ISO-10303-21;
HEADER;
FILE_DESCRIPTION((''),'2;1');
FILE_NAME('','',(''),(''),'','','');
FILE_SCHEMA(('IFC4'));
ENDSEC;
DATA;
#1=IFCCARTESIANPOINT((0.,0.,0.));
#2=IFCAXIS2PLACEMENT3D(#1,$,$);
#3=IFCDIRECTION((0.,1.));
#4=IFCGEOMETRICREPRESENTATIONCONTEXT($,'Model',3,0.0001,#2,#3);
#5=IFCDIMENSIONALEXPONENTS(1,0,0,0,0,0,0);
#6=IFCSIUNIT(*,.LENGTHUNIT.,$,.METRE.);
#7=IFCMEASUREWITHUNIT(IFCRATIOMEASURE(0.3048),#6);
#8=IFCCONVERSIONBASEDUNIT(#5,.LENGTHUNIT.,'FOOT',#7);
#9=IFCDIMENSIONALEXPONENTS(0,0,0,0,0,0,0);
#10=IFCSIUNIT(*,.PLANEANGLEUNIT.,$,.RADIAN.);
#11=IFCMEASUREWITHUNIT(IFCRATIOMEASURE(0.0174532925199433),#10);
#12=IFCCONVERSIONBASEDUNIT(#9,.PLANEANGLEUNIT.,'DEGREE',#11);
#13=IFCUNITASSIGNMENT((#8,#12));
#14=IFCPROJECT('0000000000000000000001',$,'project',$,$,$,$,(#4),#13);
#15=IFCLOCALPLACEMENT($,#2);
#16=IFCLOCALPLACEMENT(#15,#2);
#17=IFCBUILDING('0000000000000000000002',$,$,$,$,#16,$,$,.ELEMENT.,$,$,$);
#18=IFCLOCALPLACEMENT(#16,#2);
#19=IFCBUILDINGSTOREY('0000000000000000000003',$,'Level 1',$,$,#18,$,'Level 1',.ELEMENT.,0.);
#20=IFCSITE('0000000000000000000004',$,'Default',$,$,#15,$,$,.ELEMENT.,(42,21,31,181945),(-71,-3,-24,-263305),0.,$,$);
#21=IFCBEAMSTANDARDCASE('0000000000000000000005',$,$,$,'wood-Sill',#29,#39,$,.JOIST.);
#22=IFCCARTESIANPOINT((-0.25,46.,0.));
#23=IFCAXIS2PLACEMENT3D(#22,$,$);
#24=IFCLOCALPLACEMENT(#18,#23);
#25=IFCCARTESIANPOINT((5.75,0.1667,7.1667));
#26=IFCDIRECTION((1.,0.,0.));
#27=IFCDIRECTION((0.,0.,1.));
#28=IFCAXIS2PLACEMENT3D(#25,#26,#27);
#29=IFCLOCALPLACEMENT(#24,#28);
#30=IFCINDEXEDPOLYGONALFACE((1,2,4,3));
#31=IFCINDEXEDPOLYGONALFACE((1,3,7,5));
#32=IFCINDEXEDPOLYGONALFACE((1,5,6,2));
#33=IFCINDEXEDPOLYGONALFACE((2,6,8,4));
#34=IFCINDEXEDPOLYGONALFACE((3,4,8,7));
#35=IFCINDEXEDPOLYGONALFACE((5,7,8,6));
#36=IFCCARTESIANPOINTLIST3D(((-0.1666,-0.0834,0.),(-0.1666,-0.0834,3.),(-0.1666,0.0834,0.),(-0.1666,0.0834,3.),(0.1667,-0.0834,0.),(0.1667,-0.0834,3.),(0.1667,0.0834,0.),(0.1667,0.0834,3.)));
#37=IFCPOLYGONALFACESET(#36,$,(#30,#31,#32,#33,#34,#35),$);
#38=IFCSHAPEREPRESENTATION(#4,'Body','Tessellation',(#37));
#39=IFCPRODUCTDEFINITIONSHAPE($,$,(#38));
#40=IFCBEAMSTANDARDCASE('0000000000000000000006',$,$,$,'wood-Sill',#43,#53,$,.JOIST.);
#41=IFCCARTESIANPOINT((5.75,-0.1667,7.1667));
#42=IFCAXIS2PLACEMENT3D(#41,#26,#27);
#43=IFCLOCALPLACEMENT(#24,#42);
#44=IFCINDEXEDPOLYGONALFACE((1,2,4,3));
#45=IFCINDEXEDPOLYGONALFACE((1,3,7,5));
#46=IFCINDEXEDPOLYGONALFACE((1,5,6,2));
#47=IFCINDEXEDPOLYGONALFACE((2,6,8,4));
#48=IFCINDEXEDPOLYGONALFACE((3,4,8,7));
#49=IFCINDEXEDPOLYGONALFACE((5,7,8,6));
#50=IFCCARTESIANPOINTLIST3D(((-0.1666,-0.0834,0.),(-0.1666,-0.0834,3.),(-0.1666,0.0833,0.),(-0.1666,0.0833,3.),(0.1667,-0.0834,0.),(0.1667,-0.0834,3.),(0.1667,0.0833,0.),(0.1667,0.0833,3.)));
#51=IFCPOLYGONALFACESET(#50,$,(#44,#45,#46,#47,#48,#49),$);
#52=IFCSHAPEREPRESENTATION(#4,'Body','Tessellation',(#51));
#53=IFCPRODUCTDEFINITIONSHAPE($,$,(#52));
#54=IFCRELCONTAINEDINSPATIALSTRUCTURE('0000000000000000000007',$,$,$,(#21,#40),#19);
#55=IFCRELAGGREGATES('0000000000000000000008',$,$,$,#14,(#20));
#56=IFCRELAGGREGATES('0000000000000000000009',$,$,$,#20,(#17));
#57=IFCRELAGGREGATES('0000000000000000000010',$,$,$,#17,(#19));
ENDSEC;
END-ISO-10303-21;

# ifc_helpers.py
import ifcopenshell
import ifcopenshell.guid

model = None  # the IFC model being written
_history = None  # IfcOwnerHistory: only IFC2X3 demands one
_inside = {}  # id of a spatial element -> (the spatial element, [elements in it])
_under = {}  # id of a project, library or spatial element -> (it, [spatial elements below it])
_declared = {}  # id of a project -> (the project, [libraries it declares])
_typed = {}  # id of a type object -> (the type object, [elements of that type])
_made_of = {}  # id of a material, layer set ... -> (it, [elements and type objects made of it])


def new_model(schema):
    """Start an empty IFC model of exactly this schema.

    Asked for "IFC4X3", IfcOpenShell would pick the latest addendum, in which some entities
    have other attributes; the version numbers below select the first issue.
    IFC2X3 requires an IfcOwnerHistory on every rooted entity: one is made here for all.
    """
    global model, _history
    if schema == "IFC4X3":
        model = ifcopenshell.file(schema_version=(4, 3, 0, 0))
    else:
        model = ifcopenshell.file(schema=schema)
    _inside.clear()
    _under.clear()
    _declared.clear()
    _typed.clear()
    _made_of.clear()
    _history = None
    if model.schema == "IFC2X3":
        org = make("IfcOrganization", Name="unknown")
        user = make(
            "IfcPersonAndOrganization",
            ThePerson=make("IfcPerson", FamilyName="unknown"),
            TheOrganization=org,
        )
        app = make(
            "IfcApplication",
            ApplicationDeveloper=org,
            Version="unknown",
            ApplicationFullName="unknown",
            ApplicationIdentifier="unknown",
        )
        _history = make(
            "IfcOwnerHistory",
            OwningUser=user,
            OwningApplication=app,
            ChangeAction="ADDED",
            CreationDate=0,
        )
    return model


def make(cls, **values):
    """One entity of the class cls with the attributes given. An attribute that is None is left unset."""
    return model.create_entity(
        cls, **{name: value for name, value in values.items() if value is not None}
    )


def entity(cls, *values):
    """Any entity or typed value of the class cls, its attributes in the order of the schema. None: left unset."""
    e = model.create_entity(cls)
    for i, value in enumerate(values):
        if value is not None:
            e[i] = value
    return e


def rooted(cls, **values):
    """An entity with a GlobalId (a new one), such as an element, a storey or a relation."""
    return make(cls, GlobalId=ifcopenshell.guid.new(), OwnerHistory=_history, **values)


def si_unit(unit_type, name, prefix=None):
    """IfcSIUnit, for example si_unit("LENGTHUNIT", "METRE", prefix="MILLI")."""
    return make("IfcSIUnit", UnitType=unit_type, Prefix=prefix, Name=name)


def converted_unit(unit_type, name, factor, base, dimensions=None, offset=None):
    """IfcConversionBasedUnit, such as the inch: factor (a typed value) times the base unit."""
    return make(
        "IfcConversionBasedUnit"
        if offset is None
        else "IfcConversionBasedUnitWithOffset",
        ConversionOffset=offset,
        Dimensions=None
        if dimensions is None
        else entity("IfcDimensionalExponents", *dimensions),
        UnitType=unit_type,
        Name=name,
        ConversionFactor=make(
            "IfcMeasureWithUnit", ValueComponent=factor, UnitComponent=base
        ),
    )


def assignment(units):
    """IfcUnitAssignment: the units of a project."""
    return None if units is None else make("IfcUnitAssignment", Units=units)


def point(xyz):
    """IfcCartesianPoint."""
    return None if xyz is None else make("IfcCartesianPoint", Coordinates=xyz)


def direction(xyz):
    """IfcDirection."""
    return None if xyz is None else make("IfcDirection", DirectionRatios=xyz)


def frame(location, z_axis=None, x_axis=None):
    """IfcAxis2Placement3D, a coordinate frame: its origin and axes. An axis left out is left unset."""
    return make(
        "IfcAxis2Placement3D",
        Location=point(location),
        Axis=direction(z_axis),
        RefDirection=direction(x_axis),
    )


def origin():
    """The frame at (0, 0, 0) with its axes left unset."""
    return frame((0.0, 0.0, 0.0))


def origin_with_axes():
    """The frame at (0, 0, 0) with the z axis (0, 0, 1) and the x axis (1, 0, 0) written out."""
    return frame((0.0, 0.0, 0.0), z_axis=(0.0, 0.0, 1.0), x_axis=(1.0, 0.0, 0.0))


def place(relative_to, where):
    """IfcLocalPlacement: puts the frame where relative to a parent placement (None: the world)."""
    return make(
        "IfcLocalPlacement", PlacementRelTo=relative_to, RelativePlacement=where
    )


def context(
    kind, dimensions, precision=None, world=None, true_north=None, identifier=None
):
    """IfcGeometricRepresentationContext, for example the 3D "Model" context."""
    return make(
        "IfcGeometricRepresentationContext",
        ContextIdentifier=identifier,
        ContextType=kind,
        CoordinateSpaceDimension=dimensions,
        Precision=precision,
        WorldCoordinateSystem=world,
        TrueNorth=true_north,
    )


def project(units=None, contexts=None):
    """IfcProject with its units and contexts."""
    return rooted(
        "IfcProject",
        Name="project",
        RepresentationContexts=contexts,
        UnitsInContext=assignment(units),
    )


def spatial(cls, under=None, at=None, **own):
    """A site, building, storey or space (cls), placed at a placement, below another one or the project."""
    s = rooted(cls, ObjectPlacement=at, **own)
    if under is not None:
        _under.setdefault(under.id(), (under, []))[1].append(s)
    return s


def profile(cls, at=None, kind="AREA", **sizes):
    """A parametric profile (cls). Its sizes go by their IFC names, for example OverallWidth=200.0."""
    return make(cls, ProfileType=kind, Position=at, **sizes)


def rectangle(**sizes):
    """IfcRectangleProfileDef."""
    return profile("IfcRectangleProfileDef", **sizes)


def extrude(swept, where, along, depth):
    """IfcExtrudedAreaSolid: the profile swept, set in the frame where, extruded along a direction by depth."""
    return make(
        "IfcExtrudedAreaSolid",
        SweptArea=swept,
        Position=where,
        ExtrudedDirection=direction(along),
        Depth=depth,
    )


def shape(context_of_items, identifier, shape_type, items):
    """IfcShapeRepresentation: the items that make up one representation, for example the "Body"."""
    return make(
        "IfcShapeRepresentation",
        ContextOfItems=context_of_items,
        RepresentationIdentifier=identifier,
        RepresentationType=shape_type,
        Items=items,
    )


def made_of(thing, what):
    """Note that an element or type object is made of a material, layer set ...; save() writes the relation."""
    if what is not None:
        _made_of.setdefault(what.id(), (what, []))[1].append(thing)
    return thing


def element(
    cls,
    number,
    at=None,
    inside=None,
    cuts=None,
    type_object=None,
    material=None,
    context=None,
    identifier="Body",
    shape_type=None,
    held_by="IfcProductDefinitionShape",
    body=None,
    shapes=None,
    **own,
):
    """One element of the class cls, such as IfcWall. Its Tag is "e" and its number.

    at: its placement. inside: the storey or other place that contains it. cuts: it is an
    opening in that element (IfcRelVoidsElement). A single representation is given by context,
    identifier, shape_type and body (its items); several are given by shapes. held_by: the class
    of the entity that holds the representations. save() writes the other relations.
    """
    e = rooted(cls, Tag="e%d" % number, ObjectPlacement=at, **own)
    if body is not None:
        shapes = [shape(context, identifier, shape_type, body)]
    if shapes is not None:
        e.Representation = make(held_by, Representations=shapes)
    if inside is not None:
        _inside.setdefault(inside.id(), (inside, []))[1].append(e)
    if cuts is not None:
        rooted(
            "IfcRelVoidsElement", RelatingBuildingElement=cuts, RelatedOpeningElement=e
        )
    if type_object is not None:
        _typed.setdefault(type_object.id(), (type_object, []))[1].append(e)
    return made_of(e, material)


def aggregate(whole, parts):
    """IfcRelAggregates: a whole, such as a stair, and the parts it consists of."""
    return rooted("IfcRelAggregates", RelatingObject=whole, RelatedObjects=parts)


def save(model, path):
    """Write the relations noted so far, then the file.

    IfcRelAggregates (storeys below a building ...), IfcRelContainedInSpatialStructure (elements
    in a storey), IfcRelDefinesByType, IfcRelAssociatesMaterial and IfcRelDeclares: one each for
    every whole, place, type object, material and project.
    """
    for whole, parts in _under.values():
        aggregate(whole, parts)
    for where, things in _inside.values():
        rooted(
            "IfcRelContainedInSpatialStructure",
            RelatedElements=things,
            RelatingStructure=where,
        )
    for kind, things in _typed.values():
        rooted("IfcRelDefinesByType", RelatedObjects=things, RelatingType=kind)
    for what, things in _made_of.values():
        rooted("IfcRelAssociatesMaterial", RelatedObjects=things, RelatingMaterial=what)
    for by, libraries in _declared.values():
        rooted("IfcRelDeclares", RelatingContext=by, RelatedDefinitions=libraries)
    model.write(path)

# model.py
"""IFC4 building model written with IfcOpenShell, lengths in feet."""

from ifc_helpers import new_model, entity, si_unit, converted_unit, direction, frame, origin, origin_with_axes, place, context, project, spatial, rectangle, extrude, element, save


model = new_model("IFC4")

# Units and contexts
model_context = context("Model", 3, precision=0.0001, world=origin(), true_north=direction((0.0, 1.0)))
ifc_project = project(units=[converted_unit("LENGTHUNIT", "FOOT", entity("IfcRatioMeasure", 0.3048), si_unit("LENGTHUNIT", "METRE"), dimensions=[1, 0, 0, 0, 0, 0, 0]), converted_unit("PLANEANGLEUNIT", "DEGREE", entity("IfcRatioMeasure", 0.0174532925199433), si_unit("PLANEANGLEUNIT", "RADIAN"), dimensions=[0, 0, 0, 0, 0, 0, 0])], contexts=[model_context])

# Site, building, storey
site_placement = place(None, origin())
site = spatial("IfcSite", under=ifc_project, at=site_placement, Name="Default", CompositionType="ELEMENT", RefLatitude=(42, 21, 31, 181945), RefLongitude=(-71, -3, -24, -263305), RefElevation=0.0)
building_placement = place(site_placement, origin())
building = spatial("IfcBuilding", under=site, at=building_placement, CompositionType="ELEMENT")
storey_placement = place(building_placement, origin())
storey = spatial("IfcBuildingStorey", under=building, at=storey_placement, Name="Level 1", LongName="Level 1", CompositionType="ELEMENT", Elevation=0.0)

# Shared definitions
placement_1 = place(storey_placement, frame((-0.25, 46.0, 0.0)))

# Beams
for number, where, z_axis, x_axis in (
    (1, (5.75, 0.1667, 7.1667), (1.0, 0.0, 0.0), (0.0, 0.0, 1.0)),
    (2, (5.75, -0.1667, 7.1667), (1.0, 0.0, 0.0), (0.0, 0.0, 1.0)),
):
    element("IfcBeamStandardCase", number, at=place(placement_1, frame(where, z_axis=z_axis, x_axis=x_axis)), inside=storey, ObjectType="wood-Sill", PredefinedType="JOIST", context=model_context, shape_type="SweptSolid", body=[
        extrude(rectangle(XDim=0.3333, YDim=0.1667), origin_with_axes(), (0.0, 0.0, 1.0), 3.0),
    ])

save(model, "model.ifc")
